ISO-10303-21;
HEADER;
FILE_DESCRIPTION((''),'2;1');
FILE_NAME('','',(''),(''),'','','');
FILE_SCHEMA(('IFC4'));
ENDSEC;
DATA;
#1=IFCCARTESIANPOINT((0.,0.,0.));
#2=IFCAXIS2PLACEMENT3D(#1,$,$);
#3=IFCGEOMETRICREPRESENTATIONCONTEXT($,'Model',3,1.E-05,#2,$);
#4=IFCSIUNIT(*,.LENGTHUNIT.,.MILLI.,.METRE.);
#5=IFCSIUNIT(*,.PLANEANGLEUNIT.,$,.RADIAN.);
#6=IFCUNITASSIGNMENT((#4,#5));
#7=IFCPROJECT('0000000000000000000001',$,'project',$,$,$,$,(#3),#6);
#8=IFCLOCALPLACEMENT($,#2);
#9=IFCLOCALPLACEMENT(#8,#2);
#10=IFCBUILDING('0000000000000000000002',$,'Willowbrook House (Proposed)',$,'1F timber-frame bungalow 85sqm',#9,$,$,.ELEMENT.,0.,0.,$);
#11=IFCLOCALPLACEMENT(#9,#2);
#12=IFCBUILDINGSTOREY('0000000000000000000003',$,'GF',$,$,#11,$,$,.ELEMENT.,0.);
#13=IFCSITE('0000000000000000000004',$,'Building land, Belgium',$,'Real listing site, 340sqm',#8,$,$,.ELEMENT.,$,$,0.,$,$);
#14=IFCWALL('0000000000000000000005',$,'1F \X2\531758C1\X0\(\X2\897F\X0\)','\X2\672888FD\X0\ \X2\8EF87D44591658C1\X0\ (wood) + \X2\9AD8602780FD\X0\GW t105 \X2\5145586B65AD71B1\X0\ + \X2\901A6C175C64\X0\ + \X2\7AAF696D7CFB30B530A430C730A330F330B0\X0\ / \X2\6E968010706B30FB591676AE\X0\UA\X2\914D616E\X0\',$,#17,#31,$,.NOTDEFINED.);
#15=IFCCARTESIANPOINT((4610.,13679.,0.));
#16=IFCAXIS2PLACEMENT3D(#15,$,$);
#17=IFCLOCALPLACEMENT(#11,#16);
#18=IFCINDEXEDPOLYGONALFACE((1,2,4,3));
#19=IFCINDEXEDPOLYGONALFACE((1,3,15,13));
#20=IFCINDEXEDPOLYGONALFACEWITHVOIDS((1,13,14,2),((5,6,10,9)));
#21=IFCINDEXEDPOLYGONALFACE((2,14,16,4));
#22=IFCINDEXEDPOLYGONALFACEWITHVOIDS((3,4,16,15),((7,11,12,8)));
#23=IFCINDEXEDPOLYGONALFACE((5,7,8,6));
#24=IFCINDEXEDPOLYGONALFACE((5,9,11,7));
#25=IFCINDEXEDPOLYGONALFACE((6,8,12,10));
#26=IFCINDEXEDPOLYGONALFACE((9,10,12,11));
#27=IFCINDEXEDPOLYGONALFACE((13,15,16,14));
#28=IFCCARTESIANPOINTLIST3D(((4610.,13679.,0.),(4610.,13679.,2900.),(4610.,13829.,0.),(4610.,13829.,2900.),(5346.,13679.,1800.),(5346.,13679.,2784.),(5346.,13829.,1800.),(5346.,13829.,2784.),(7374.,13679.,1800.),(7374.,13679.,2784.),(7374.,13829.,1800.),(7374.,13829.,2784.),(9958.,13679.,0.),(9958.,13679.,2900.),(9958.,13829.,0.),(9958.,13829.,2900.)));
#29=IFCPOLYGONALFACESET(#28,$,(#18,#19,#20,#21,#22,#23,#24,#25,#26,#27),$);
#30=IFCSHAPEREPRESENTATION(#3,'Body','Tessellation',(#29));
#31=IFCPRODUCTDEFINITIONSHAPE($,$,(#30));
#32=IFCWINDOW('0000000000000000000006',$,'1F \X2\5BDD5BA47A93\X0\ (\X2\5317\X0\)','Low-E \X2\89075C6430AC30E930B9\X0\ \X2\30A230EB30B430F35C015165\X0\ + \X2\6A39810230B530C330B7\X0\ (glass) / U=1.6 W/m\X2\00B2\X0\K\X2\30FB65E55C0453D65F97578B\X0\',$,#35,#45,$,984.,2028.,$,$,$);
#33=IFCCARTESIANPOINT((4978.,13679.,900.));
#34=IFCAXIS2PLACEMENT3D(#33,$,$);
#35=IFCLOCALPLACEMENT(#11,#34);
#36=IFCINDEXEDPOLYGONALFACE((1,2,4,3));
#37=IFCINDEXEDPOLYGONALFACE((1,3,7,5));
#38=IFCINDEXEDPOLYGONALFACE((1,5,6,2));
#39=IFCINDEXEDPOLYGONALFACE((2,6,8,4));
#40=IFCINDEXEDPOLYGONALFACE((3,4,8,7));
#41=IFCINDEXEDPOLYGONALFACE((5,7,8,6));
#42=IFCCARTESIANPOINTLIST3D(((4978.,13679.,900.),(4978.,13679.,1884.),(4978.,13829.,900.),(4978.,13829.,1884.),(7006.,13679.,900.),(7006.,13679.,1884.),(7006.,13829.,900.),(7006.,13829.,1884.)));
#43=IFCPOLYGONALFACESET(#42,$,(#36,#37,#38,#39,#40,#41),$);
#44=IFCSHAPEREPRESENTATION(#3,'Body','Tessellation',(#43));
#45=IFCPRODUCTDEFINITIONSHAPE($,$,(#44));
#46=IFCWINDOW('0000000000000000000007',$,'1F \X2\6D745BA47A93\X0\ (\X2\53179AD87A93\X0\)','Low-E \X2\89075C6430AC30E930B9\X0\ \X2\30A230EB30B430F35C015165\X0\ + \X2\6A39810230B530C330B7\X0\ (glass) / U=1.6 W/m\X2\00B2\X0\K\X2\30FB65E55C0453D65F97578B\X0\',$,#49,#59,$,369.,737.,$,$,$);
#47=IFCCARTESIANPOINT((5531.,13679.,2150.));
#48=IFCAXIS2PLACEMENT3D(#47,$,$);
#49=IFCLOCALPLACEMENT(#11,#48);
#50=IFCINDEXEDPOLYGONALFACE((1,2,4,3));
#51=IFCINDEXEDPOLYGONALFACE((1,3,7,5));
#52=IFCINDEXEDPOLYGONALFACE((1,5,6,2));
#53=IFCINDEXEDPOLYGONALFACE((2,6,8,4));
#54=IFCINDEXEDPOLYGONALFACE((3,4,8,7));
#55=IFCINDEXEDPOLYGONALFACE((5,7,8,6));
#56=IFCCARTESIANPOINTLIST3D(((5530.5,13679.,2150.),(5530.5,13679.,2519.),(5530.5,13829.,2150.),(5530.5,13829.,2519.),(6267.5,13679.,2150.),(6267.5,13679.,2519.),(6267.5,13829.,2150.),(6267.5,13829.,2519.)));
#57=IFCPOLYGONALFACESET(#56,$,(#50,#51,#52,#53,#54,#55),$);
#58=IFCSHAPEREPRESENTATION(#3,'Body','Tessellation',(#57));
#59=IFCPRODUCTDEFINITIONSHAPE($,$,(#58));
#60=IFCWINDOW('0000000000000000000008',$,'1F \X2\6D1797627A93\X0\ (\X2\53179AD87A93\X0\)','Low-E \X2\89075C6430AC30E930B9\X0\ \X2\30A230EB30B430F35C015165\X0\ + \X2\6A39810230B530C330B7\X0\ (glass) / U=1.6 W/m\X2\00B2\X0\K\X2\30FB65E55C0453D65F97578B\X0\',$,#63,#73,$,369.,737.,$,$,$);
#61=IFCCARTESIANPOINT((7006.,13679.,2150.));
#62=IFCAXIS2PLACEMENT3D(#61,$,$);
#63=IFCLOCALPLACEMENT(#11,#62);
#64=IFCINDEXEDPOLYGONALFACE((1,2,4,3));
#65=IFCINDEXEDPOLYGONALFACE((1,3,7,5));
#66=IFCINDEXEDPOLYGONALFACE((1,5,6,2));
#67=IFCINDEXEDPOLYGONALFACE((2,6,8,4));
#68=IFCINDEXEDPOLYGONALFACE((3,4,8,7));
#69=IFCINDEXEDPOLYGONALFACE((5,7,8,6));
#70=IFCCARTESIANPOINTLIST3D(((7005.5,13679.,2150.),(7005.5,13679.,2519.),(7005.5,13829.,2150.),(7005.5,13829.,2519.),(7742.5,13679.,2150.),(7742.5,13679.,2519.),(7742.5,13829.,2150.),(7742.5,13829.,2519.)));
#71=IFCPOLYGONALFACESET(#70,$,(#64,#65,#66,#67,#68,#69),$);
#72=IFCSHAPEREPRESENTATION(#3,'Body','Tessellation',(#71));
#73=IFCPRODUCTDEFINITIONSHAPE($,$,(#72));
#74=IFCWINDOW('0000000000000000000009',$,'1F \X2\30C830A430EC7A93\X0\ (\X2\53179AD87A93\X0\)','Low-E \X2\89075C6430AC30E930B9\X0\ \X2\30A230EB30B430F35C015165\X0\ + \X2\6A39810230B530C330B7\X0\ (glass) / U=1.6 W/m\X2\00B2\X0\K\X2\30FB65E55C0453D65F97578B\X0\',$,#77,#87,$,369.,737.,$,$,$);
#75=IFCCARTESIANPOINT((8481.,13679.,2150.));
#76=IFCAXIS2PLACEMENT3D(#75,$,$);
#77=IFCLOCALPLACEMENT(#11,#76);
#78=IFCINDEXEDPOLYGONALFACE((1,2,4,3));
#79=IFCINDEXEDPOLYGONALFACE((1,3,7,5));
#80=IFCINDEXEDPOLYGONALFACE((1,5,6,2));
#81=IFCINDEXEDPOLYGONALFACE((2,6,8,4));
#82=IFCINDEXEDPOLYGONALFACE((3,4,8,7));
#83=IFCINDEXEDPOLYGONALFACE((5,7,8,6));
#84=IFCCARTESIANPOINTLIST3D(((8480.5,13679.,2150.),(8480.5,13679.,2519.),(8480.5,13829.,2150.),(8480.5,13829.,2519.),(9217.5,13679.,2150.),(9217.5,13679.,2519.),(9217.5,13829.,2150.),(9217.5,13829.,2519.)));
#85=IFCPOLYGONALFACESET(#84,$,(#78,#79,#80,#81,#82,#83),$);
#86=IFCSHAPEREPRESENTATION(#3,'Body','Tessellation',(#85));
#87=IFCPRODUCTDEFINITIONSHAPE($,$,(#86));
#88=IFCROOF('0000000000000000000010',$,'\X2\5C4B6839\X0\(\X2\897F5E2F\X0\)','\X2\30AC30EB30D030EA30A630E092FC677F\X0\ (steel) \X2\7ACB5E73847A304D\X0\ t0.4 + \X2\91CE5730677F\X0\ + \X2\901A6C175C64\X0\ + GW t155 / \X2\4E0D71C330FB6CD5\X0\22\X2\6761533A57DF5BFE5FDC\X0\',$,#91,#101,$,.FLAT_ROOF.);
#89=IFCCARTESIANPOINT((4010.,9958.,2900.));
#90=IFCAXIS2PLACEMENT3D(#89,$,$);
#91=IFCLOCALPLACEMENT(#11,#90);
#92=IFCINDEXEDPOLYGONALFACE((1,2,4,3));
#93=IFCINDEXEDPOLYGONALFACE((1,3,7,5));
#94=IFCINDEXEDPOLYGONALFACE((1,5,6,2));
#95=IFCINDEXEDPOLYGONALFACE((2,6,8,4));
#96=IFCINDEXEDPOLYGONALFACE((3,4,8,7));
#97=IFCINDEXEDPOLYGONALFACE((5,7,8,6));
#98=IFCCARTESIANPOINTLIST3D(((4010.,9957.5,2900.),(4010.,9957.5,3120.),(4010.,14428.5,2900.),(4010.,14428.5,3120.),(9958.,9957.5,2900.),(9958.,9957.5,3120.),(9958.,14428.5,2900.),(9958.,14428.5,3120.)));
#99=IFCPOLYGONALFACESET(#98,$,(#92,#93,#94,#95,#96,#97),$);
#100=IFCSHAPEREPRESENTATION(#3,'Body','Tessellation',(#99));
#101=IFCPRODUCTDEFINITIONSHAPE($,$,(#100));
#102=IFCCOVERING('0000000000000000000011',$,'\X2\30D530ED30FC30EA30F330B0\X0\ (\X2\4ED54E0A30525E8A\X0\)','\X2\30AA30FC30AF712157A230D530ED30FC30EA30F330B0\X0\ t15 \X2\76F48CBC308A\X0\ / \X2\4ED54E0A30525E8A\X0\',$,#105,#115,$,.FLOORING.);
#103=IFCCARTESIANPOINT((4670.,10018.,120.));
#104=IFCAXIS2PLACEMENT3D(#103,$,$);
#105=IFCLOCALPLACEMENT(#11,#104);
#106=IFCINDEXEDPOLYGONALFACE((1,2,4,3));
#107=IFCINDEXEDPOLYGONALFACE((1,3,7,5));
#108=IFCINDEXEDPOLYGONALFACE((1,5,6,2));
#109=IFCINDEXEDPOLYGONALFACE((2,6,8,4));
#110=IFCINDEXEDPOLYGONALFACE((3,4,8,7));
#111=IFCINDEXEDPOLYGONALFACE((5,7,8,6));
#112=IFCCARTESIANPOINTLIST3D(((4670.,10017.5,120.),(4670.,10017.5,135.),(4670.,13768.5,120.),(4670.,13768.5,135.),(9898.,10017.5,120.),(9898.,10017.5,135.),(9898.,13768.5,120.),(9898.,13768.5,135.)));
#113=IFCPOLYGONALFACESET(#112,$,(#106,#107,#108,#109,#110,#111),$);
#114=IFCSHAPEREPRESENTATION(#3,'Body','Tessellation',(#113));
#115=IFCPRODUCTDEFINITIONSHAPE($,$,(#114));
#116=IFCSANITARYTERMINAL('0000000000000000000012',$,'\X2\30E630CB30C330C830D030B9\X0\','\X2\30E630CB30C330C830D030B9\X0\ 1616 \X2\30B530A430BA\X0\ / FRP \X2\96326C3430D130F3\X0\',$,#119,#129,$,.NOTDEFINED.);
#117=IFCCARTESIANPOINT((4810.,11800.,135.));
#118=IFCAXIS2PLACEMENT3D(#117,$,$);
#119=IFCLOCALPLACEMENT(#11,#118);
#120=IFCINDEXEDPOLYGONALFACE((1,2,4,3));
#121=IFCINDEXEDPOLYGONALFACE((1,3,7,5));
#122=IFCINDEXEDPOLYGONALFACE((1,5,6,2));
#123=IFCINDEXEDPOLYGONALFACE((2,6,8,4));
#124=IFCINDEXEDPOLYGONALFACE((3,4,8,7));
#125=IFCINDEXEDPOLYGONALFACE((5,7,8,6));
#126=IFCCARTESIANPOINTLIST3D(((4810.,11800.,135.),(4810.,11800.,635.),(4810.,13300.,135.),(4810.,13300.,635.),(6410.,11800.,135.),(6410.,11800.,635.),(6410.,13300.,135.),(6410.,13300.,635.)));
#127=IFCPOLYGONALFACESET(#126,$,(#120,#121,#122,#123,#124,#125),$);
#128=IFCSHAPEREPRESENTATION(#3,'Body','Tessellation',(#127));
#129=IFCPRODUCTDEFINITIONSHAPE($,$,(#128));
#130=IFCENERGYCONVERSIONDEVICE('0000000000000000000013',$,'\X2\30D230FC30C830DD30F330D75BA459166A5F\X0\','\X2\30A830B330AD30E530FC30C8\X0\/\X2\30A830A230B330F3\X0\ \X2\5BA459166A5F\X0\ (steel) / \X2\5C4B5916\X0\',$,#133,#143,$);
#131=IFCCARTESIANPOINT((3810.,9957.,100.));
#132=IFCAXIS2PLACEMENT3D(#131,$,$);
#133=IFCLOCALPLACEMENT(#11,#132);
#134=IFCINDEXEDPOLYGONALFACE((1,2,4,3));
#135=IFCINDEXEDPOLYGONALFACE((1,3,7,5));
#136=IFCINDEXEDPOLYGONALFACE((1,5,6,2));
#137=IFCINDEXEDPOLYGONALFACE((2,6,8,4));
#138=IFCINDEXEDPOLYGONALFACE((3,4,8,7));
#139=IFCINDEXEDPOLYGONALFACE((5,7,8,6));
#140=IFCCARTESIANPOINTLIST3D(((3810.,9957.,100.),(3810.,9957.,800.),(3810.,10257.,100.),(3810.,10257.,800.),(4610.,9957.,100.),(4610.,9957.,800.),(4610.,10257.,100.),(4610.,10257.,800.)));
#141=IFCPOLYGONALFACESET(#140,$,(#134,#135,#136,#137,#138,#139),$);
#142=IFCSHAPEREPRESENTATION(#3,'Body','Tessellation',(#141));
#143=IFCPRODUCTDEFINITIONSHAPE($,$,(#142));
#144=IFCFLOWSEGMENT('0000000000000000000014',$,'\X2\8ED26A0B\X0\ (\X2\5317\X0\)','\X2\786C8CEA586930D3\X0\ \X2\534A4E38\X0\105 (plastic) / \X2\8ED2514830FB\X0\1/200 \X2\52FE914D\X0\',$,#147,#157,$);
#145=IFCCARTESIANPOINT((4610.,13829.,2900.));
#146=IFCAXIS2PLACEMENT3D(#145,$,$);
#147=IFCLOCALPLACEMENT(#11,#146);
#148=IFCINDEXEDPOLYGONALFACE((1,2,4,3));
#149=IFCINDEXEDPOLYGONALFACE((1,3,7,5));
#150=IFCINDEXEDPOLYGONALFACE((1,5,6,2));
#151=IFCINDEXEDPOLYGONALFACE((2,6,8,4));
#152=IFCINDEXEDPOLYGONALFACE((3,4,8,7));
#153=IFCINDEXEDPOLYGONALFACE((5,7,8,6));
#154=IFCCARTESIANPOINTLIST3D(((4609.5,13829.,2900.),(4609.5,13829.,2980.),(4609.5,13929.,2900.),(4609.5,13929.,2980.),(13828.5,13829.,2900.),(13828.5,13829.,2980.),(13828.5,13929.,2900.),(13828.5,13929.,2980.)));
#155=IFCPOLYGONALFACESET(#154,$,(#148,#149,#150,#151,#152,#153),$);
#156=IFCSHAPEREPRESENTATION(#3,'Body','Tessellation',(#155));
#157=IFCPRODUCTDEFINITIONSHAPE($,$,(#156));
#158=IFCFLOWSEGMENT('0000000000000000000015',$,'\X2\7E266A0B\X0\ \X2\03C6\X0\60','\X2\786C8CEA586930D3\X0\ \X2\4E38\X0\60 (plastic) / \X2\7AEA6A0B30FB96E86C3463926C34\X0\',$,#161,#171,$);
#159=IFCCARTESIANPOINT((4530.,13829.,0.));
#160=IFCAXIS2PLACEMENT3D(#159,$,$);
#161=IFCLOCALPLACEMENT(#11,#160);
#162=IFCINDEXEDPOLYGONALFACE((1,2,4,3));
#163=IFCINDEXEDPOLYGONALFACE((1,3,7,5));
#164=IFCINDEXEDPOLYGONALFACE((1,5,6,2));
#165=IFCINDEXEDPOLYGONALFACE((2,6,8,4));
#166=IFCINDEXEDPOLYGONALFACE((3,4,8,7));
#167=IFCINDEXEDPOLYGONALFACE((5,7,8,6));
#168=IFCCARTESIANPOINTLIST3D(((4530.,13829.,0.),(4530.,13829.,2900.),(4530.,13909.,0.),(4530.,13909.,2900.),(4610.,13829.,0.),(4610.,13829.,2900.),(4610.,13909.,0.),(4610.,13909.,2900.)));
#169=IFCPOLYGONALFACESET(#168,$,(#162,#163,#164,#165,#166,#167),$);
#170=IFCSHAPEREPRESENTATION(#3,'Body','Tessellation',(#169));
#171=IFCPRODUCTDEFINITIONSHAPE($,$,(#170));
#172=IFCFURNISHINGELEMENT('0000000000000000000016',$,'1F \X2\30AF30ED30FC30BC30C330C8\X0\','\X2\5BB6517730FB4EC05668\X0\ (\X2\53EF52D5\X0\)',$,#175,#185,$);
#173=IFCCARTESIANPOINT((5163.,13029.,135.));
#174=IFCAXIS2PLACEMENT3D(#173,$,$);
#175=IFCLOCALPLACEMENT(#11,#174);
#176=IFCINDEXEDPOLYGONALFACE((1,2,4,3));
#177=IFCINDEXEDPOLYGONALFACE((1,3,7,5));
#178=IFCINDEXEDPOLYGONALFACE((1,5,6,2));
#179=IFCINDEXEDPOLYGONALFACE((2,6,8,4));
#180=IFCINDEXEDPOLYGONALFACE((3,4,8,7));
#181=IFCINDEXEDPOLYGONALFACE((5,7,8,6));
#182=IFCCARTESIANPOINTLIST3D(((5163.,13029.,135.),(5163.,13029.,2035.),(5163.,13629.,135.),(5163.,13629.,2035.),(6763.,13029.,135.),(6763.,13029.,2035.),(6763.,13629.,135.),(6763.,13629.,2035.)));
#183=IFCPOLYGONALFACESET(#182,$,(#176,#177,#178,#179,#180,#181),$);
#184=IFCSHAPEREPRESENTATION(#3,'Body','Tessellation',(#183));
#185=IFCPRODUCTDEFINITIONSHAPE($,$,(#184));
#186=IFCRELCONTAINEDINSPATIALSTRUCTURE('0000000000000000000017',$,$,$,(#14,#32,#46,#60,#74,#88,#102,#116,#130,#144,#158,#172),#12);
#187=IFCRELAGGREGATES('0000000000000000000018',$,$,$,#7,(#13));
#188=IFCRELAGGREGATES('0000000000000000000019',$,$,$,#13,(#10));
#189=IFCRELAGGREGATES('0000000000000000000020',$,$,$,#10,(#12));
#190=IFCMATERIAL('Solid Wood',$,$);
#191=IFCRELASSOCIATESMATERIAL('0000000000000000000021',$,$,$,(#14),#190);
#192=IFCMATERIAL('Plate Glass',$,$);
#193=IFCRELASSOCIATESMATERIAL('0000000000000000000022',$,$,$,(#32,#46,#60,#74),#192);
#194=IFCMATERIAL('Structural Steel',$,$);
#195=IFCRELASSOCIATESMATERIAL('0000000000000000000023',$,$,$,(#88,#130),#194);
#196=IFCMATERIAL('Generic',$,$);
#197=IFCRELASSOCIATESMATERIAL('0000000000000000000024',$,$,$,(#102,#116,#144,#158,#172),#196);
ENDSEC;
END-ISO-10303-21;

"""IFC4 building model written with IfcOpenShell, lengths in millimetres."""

from ifc_helpers import new_model, si_unit, frame, frame_2d, origin, place, context, project, spatial, rectangle, extrude, material, element, fill, save


model = new_model("IFC4")

# Units and contexts
model_context = context("Model", 3, precision=1e-05, world=origin())
ifc_project = project(units=[si_unit("LENGTHUNIT", "METRE", prefix="MILLI"), si_unit("PLANEANGLEUNIT", "RADIAN")], contexts=[model_context])

# Site, building, storey
site_placement = place(None, origin())
site = spatial("IfcSite", under=ifc_project, at=site_placement, Name="Building land, Belgium", ObjectType="Real listing site, 340sqm", CompositionType="ELEMENT", RefElevation=0.0)
building_placement = place(site_placement, origin())
building = spatial("IfcBuilding", under=site, at=building_placement, Name="Willowbrook House (Proposed)", ObjectType="1F timber-frame bungalow 85sqm", CompositionType="ELEMENT", ElevationOfRefHeight=0.0, ElevationOfTerrain=0.0)
storey_placement = place(building_placement, origin())
storey = spatial("IfcBuildingStorey", under=building, at=storey_placement, Name="GF", CompositionType="ELEMENT", Elevation=0.0)

# Shared definitions
ifc_material_1 = material(Name="Solid Wood")

# Wall, openings, windows
wall_1_placement = place(storey_placement, frame((4610.0, 13679.0, 0.0)))
wall_1 = element("IfcWall", 1, at=wall_1_placement, inside=storey, material=ifc_material_1, Name="1F 北壁(西)", Description="木製 軸組外壁 (wood) + 高性能GW t105 充填断熱 + 通気層 + 窯業系サイディング / 準耐火・外皮UA配慮", PredefinedType="NOTDEFINED", context=model_context, shape_type="SweptSolid", body=[
    extrude(rectangle(XDim=5348.0, YDim=150.0, at=frame_2d((2674.0, 75.0))), frame((4610.0, 13679.0, 0.0)), (0.0, 0.0, 1.0), 2900.0),
])
opening_1_placement = place(storey_placement, frame((4978.0, 13679.0, 900.0)))
opening_1 = element("IfcOpeningElement", 2, at=opening_1_placement, cuts=wall_1, PredefinedType="NOTDEFINED", context=model_context, shape_type="SweptSolid", body=[
    extrude(rectangle(XDim=2028.0, YDim=150.0, at=frame_2d((1014.0, 75.0))), frame((4978.0, 13679.0, 900.0)), (0.0, 0.0, 1.0), 984.0),
])
opening_2_placement = place(storey_placement, frame((5531.0, 13679.0, 2150.0)))
opening_2 = element("IfcOpeningElement", 3, at=opening_2_placement, cuts=wall_1, PredefinedType="NOTDEFINED", context=model_context, shape_type="SweptSolid", body=[
    extrude(rectangle(XDim=737.0, YDim=150.0, at=frame_2d((368.0, 75.0))), frame((5531.0, 13679.0, 2150.0)), (0.0, 0.0, 1.0), 369.0),
])
opening_3_placement = place(storey_placement, frame((7006.0, 13679.0, 2150.0)))
opening_3 = element("IfcOpeningElement", 4, at=opening_3_placement, cuts=wall_1, PredefinedType="NOTDEFINED", context=model_context, shape_type="SweptSolid", body=[
    extrude(rectangle(XDim=737.0, YDim=150.0, at=frame_2d((368.0, 75.0))), frame((7006.0, 13679.0, 2150.0)), (0.0, 0.0, 1.0), 369.0),
])
opening_4_placement = place(storey_placement, frame((8481.0, 13679.0, 2150.0)))
opening_4 = element("IfcOpeningElement", 5, at=opening_4_placement, cuts=wall_1, PredefinedType="NOTDEFINED", context=model_context, shape_type="SweptSolid", body=[
    extrude(rectangle(XDim=737.0, YDim=150.0, at=frame_2d((368.0, 75.0))), frame((8481.0, 13679.0, 2150.0)), (0.0, 0.0, 1.0), 369.0),
])
ifc_material_2 = material(Name="Plate Glass")
window_1_placement = place(storey_placement, frame((4978.0, 13679.0, 900.0)))
window_1 = element("IfcWindow", 6, at=window_1_placement, inside=storey, material=ifc_material_2, Name="1F 寝室窓 (北)", Description="Low-E 複層ガラス アルゴン封入 + 樹脂サッシ (glass) / U=1.6 W/m²K・日射取得型", OverallHeight=984.0, OverallWidth=2028.0, context=model_context, shape_type="SweptSolid", body=[
    extrude(rectangle(XDim=2028.0, YDim=150.0, at=frame_2d((1014.0, 75.0))), frame((4978.0, 13679.0, 900.0)), (0.0, 0.0, 1.0), 984.0),
])
fill(opening_1, window_1)
window_2_placement = place(storey_placement, frame((5531.0, 13679.0, 2150.0)))
window_2 = element("IfcWindow", 7, at=window_2_placement, inside=storey, material=ifc_material_2, Name="1F 浴室窓 (北高窓)", Description="Low-E 複層ガラス アルゴン封入 + 樹脂サッシ (glass) / U=1.6 W/m²K・日射取得型", OverallHeight=369.0, OverallWidth=737.0, context=model_context, shape_type="SweptSolid", body=[
    extrude(rectangle(XDim=737.0, YDim=150.0, at=frame_2d((368.0, 75.0))), frame((5531.0, 13679.0, 2150.0)), (0.0, 0.0, 1.0), 369.0),
])
fill(opening_2, window_2)
window_3_placement = place(storey_placement, frame((7006.0, 13679.0, 2150.0)))
window_3 = element("IfcWindow", 8, at=window_3_placement, inside=storey, material=ifc_material_2, Name="1F 洗面窓 (北高窓)", Description="Low-E 複層ガラス アルゴン封入 + 樹脂サッシ (glass) / U=1.6 W/m²K・日射取得型", OverallHeight=369.0, OverallWidth=737.0, context=model_context, shape_type="SweptSolid", body=[
    extrude(rectangle(XDim=737.0, YDim=150.0, at=frame_2d((368.0, 75.0))), frame((7006.0, 13679.0, 2150.0)), (0.0, 0.0, 1.0), 369.0),
])
fill(opening_3, window_3)
window_4_placement = place(storey_placement, frame((8481.0, 13679.0, 2150.0)))
window_4 = element("IfcWindow", 9, at=window_4_placement, inside=storey, material=ifc_material_2, Name="1F トイレ窓 (北高窓)", Description="Low-E 複層ガラス アルゴン封入 + 樹脂サッシ (glass) / U=1.6 W/m²K・日射取得型", OverallHeight=369.0, OverallWidth=737.0, context=model_context, shape_type="SweptSolid", body=[
    extrude(rectangle(XDim=737.0, YDim=150.0, at=frame_2d((368.0, 75.0))), frame((8481.0, 13679.0, 2150.0)), (0.0, 0.0, 1.0), 369.0),
])
fill(opening_4, window_4)

# Roof
ifc_material_3 = material(Name="Structural Steel")
roof_placement = place(storey_placement, frame((4010.0, 9958.0, 2900.0)))
element("IfcRoof", 10, at=roof_placement, inside=storey, material=ifc_material_3, Name="屋根(西帯)", Description="ガルバリウム鋼板 (steel) 立平葺き t0.4 + 野地板 + 通気層 + GW t155 / 不燃・法22条区域対応", PredefinedType="FLAT_ROOF", context=model_context, shape_type="SweptSolid", body=[
    extrude(rectangle(XDim=5948.0, YDim=4471.0, at=frame_2d((2974.0, 2235.0))), frame((4010.0, 9958.0, 2900.0)), (0.0, 0.0, 1.0), 220.0),
])

# Covering
ifc_material_4 = material(Name="Generic")
covering_placement = place(storey_placement, frame((4670.0, 10018.0, 120.0)))
element("IfcCovering", 11, at=covering_placement, inside=storey, material=ifc_material_4, Name="フローリング (仕上げ床)", Description="オーク無垢フローリング t15 直貼り / 仕上げ床", PredefinedType="FLOORING", context=model_context, shape_type="SweptSolid", body=[
    extrude(rectangle(XDim=5228.0, YDim=3751.0, at=frame_2d((2614.0, 1875.0))), frame((4670.0, 10018.0, 120.0)), (0.0, 0.0, 1.0), 15.0),
])

# Sanitary terminal
sanitary_terminal_placement = place(storey_placement, frame((4810.0, 11800.0, 135.0)))
element("IfcSanitaryTerminal", 12, at=sanitary_terminal_placement, inside=storey, material=ifc_material_4, Name="ユニットバス", Description="ユニットバス 1616 サイズ / FRP 防水パン", PredefinedType="NOTDEFINED", context=model_context, shape_type="SweptSolid", body=[
    extrude(rectangle(XDim=1600.0, YDim=1500.0, at=frame_2d((800.0, 750.0))), frame((4810.0, 11800.0, 135.0)), (0.0, 0.0, 1.0), 500.0),
])

# Energy conversion device
energy_conversion_device_placement = place(storey_placement, frame((3810.0, 9957.0, 100.0)))
element("IfcEnergyConversionDevice", 13, at=energy_conversion_device_placement, inside=storey, material=ifc_material_3, Name="ヒートポンプ室外機", Description="エコキュート/エアコン 室外機 (steel) / 屋外", context=model_context, shape_type="SweptSolid", body=[
    extrude(rectangle(XDim=800.0, YDim=300.0, at=frame_2d((400.0, 150.0))), frame((3810.0, 9957.0, 100.0)), (0.0, 0.0, 1.0), 700.0),
])

# Flow segments
flow_segment_1_placement = place(storey_placement, frame((4610.0, 13829.0, 2900.0)))
element("IfcFlowSegment", 14, at=flow_segment_1_placement, inside=storey, material=ifc_material_4, Name="軒樋 (北)", Description="硬質塩ビ 半丸105 (plastic) / 軒先・1/200 勾配", context=model_context, shape_type="SweptSolid", body=[
    extrude(rectangle(XDim=9219.0, YDim=100.0, at=frame_2d((4609.0, 50.0))), frame((4610.0, 13829.0, 2900.0)), (0.0, 0.0, 1.0), 80.0),
])
flow_segment_2_placement = place(storey_placement, frame((4530.0, 13829.0, 0.0)))
element("IfcFlowSegment", 15, at=flow_segment_2_placement, inside=storey, material=ifc_material_4, Name="縦樋 φ60", Description="硬質塩ビ 丸60 (plastic) / 竪樋・雨水排水", context=model_context, shape_type="SweptSolid", body=[
    extrude(rectangle(XDim=80.0, YDim=80.0, at=frame_2d((40.0, 40.0))), frame((4530.0, 13829.0, 0.0)), (0.0, 0.0, 1.0), 2900.0),
])

# Furnishing element
furnishing_1_placement = place(storey_placement, frame((5163.0, 13029.0, 135.0)))
element("IfcFurnishingElement", 16, at=furnishing_1_placement, inside=storey, material=ifc_material_4, Name="1F クローゼット", Description="家具・什器 (可動)", context=model_context, shape_type="SweptSolid", body=[
    extrude(rectangle(XDim=1600.0, YDim=600.0, at=frame_2d((800.0, 300.0))), frame((5163.0, 13029.0, 135.0)), (0.0, 0.0, 1.0), 1900.0),
])

save(model, "model.ifc")
